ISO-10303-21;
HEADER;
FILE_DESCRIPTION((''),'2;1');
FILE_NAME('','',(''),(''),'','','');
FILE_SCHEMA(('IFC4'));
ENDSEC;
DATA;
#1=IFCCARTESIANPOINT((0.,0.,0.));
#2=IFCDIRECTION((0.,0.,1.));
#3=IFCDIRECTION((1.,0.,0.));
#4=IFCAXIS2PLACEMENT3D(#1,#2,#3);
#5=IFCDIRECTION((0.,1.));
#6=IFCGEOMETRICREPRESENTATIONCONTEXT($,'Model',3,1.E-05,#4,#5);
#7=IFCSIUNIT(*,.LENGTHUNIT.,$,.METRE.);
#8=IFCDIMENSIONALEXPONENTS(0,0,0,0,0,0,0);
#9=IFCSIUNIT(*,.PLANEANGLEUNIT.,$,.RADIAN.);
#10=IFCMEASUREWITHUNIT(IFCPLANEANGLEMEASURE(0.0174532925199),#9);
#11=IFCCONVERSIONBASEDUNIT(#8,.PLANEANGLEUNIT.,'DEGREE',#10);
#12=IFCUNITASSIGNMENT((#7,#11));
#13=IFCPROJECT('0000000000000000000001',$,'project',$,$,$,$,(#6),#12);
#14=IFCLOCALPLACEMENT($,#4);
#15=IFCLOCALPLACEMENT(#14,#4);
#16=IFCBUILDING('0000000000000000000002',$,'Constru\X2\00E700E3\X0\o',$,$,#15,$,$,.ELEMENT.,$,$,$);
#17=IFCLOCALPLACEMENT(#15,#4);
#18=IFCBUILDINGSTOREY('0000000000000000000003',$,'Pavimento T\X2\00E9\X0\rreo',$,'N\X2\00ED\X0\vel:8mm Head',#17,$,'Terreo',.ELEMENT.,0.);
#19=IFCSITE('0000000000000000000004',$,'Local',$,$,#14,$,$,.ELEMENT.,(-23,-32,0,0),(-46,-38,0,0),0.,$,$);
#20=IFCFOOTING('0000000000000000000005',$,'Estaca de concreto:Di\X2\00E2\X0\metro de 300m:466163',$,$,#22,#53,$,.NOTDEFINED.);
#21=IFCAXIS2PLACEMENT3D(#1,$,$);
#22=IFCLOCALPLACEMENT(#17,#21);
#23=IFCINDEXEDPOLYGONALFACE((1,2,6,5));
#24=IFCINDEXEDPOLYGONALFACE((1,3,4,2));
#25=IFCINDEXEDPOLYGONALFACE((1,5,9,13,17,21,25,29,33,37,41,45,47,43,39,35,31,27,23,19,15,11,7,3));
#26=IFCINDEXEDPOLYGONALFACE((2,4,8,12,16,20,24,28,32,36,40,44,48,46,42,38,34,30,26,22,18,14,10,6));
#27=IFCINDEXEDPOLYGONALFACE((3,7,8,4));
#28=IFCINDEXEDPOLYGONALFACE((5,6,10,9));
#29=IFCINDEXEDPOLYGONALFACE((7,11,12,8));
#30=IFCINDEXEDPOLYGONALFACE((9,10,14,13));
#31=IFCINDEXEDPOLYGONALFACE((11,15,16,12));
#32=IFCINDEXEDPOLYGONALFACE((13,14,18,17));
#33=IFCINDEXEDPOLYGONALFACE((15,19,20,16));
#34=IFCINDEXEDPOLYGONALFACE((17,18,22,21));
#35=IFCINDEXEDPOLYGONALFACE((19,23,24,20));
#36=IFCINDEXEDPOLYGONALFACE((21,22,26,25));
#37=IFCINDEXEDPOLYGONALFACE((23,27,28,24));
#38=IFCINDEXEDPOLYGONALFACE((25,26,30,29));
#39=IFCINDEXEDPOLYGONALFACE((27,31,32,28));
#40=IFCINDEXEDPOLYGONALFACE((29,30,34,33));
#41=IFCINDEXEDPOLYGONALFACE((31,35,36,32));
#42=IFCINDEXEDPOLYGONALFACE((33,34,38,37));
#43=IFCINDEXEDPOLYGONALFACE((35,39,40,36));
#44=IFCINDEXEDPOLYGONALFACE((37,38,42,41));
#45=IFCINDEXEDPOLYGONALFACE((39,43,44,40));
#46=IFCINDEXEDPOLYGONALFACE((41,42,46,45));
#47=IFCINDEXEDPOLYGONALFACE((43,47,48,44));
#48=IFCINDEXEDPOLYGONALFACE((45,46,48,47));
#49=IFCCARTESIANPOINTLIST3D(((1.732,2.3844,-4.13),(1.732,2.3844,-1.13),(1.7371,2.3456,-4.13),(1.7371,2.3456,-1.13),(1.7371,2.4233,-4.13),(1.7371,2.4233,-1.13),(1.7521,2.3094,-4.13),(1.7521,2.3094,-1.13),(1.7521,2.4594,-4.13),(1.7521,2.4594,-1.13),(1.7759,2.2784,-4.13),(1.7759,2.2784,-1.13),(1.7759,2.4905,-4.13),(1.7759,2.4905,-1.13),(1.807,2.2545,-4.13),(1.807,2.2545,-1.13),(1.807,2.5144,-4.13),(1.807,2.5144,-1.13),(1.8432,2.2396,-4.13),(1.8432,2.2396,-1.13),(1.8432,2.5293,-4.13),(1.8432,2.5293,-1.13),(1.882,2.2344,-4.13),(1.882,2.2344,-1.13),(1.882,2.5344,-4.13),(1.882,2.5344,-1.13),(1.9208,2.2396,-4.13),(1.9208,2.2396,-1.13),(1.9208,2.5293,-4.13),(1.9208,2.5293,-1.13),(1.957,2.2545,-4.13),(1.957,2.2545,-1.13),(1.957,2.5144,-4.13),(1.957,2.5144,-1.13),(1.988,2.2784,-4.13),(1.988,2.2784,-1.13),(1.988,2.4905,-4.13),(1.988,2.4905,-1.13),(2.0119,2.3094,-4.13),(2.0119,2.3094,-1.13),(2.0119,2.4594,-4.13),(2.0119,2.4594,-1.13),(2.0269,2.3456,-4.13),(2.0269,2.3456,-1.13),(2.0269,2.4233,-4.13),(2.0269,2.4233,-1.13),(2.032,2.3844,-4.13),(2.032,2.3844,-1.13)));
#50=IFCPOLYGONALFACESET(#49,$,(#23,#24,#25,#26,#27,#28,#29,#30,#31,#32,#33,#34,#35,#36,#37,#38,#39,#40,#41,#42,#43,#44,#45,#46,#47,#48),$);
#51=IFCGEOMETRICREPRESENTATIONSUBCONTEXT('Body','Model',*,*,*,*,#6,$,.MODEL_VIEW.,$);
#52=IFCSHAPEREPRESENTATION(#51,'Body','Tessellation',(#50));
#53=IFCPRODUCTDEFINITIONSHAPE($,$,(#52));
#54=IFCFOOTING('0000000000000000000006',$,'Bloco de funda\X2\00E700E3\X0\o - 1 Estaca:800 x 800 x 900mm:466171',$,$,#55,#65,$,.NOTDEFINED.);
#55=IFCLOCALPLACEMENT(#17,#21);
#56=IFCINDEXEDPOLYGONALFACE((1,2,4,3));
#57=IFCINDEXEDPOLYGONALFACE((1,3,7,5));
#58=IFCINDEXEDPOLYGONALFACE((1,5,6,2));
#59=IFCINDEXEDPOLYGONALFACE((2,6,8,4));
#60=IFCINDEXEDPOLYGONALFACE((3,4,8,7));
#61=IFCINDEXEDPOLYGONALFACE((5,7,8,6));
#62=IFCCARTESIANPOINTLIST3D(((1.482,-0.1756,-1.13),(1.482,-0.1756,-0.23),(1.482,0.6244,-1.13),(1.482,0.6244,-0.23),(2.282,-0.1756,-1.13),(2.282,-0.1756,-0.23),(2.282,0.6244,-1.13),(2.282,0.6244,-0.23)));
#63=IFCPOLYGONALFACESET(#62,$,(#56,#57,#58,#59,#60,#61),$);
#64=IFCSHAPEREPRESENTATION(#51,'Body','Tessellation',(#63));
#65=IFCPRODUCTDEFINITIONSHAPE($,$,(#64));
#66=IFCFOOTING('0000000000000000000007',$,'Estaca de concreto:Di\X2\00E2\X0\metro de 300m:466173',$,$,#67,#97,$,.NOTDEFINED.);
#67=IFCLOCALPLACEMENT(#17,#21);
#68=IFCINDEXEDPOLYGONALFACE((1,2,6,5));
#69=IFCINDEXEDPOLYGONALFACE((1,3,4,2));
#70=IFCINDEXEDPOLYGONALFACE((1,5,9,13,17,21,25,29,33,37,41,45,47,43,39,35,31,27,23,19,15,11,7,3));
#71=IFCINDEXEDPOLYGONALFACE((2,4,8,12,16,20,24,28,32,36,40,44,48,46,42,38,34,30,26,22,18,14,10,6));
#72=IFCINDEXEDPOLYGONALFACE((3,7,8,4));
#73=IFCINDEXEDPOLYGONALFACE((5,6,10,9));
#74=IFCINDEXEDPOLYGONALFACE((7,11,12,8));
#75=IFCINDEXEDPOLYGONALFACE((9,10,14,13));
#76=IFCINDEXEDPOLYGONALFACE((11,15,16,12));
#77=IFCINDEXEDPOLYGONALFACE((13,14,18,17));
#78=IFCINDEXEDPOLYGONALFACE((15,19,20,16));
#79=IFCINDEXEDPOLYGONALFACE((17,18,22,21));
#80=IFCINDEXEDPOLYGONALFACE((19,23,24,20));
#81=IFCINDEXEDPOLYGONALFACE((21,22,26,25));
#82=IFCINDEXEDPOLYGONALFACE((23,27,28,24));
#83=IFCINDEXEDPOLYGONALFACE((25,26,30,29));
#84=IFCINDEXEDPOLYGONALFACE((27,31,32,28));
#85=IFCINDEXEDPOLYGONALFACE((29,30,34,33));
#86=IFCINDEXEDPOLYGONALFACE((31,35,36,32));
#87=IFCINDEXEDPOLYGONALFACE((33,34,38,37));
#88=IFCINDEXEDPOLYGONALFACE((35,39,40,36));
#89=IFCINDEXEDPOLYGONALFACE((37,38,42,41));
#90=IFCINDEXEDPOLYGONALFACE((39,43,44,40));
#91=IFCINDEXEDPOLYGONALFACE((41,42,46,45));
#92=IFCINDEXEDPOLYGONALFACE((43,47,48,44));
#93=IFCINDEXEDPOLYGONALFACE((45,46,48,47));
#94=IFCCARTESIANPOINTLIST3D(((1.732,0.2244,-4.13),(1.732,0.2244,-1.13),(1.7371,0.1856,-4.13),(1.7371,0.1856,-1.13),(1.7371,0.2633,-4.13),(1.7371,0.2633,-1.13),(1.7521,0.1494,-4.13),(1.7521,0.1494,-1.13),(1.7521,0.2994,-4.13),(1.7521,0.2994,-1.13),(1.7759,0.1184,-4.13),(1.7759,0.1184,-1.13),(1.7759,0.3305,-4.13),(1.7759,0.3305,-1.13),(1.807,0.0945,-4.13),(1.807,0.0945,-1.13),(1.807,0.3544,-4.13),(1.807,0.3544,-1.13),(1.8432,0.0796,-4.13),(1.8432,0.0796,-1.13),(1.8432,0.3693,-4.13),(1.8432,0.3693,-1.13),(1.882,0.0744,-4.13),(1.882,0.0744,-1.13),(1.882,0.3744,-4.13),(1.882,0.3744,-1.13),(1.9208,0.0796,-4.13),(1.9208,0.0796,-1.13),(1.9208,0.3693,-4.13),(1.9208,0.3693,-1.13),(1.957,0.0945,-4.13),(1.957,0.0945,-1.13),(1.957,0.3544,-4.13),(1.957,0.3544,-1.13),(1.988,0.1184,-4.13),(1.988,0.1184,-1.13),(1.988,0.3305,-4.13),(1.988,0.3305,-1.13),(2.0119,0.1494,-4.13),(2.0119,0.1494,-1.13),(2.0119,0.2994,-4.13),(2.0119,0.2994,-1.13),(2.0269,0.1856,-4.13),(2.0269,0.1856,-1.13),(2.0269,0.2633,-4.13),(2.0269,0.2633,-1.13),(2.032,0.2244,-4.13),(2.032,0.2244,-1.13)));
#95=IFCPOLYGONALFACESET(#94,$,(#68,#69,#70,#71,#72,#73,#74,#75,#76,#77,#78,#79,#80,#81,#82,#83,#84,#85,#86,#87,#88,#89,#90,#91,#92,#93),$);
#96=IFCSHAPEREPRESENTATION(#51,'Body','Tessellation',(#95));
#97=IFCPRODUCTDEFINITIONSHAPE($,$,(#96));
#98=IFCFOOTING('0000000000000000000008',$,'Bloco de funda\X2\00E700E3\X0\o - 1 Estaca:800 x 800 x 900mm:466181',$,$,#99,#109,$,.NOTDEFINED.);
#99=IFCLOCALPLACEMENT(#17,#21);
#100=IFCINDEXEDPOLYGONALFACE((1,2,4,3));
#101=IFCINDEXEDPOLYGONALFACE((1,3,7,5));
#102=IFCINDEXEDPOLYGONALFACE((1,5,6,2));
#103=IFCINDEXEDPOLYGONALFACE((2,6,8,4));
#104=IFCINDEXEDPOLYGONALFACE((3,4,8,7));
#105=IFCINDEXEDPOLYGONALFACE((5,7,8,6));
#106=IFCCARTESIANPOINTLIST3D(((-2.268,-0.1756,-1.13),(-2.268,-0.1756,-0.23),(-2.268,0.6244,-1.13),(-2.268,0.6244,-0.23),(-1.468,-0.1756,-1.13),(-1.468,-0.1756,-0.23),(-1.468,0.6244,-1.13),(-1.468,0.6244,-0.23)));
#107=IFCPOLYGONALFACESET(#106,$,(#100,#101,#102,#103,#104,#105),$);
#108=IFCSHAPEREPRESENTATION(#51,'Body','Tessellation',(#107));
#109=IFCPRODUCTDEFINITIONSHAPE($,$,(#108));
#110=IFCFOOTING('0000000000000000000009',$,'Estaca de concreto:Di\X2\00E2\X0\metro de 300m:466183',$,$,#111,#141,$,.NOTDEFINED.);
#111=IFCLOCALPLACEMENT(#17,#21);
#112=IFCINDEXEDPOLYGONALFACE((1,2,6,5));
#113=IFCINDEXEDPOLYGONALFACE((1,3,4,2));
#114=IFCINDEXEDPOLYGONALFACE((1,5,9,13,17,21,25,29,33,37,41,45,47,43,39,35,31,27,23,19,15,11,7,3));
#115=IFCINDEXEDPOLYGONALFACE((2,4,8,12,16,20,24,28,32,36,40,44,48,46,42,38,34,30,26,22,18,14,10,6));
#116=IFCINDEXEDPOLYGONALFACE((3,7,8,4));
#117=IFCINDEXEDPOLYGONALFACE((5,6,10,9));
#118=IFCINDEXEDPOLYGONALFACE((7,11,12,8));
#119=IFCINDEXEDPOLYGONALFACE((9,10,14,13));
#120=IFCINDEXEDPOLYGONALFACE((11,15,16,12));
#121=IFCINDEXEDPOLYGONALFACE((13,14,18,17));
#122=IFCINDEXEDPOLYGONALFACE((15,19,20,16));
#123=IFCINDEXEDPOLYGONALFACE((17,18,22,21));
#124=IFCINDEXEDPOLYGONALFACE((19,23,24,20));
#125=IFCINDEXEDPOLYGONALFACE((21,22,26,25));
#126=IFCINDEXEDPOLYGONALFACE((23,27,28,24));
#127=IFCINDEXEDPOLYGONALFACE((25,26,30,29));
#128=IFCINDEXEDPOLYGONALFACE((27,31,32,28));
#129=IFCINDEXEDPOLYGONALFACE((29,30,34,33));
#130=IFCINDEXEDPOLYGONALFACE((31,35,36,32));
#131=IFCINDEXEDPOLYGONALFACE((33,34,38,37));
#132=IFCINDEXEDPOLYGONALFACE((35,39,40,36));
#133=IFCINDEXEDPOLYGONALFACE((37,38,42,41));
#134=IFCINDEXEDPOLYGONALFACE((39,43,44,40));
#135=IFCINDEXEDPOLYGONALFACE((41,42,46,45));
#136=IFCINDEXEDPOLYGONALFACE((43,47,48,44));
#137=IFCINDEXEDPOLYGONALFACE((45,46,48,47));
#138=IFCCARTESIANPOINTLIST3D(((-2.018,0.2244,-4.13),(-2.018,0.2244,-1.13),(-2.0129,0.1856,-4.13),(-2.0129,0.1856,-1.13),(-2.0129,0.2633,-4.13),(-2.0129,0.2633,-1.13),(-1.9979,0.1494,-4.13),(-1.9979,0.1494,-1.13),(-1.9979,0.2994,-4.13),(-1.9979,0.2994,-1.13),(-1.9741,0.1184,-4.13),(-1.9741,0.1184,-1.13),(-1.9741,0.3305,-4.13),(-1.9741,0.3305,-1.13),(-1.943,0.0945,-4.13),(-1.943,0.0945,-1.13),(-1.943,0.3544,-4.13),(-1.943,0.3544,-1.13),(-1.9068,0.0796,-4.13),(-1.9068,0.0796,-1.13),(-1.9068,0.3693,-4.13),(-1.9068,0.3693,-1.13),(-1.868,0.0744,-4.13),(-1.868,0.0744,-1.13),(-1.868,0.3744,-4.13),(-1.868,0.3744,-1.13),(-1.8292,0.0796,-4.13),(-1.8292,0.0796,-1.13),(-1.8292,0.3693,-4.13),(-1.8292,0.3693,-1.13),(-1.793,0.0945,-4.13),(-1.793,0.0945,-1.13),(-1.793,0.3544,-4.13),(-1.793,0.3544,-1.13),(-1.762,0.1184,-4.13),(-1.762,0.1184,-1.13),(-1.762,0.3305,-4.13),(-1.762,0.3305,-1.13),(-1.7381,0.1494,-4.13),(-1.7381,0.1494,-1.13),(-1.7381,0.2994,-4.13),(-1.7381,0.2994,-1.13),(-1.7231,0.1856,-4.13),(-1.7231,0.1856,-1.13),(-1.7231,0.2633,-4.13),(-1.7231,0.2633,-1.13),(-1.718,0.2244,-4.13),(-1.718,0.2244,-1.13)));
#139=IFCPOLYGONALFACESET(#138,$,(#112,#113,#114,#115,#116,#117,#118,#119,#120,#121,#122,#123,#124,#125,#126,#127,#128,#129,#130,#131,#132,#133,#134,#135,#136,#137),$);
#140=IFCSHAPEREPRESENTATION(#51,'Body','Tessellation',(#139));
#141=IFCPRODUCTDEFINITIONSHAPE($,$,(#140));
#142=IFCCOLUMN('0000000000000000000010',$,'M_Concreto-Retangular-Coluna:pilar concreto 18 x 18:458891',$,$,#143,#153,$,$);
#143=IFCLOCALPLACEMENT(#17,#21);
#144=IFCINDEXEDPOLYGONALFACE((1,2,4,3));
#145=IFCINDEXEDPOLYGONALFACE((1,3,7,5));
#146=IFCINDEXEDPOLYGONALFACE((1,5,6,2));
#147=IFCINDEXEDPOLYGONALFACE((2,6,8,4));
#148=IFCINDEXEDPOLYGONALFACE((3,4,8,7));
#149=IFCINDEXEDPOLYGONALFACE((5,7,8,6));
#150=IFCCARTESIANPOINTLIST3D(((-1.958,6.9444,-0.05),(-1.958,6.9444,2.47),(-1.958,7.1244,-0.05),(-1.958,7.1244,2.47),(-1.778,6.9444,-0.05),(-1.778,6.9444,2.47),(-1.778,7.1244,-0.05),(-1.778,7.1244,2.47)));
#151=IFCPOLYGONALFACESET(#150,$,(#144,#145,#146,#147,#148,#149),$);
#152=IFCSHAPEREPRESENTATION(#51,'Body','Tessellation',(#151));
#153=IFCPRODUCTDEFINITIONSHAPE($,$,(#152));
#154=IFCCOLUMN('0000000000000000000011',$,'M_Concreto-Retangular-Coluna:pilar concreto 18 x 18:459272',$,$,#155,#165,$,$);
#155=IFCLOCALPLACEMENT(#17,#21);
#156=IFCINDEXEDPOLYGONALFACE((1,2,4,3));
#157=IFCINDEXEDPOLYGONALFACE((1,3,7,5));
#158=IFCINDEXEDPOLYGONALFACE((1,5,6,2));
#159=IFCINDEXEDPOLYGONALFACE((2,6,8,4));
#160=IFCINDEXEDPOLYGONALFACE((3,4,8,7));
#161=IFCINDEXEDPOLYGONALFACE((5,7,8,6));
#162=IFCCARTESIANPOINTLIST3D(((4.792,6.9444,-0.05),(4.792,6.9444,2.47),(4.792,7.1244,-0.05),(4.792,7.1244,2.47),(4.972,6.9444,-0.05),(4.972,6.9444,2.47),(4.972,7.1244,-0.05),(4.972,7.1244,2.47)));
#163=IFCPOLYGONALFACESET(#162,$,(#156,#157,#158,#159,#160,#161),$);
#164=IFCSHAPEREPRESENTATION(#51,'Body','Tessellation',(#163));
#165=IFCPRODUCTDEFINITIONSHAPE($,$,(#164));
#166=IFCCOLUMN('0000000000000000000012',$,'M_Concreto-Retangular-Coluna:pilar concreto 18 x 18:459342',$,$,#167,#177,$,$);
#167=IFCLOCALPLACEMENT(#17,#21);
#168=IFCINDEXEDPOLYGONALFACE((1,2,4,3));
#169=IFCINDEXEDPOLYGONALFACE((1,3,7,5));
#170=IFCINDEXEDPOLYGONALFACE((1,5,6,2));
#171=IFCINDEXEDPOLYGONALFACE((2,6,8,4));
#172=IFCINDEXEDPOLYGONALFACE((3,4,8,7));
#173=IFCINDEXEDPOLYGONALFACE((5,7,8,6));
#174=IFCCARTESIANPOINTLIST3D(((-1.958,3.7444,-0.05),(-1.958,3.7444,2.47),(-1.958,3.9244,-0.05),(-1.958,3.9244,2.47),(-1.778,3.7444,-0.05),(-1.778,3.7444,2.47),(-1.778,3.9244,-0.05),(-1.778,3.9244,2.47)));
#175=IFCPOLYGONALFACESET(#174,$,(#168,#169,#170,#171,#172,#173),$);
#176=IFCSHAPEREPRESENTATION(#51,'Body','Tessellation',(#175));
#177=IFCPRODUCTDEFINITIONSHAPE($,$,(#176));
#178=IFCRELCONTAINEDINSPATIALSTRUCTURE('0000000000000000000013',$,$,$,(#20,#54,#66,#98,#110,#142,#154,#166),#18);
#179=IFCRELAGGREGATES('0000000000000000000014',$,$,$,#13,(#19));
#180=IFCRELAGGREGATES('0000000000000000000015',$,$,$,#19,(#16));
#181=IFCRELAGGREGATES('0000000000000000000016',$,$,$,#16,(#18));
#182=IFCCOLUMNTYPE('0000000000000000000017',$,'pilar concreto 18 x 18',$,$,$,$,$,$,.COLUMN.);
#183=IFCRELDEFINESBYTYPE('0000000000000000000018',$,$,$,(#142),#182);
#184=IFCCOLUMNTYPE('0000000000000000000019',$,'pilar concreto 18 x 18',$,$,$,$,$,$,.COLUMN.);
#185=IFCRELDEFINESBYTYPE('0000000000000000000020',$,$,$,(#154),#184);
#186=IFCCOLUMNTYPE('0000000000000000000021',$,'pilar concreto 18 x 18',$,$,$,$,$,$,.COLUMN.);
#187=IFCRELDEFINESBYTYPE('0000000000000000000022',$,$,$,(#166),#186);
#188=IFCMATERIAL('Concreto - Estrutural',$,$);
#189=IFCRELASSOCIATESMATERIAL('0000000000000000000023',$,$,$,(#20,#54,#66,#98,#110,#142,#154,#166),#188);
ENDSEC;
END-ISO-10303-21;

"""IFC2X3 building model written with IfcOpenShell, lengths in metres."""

from ifc_helpers import new_model, entity, si_unit, converted_unit, point, direction, frame, frame_2d, origin_with_axes, origin_2d_with_axis, place, context, subcontext, project, spatial, polyline, circle_curve, parameter, trimmed, segment, composite_curve, rectangle, outline, extrude, material, type_object, element, save


model = new_model("IFC2X3")

# Units and contexts
model_context = context("Model", 3, precision=1e-05, world=origin_with_axes(), true_north=direction((0.0, 1.0)))
body_context = subcontext(model_context, "Body", "Model", "MODEL_VIEW")
ifc_project = project(units=[si_unit("LENGTHUNIT", "METRE"), converted_unit("PLANEANGLEUNIT", "DEGREE", entity("IfcPlaneAngleMeasure", 0.0174532925199), si_unit("PLANEANGLEUNIT", "RADIAN"), dimensions=[0, 0, 0, 0, 0, 0, 0])], contexts=[model_context])

# Site, building, storey
site_placement = place(None, origin_with_axes())
site = spatial("IfcSite", under=ifc_project, at=site_placement, Name="Local", CompositionType="ELEMENT", RefLatitude=(-23, -32, 0, 0), RefLongitude=(-46, -38, 0, 0), RefElevation=0.0)
building_placement = place(site_placement, origin_with_axes())
building = spatial("IfcBuilding", under=site, at=building_placement, Name="Construção", CompositionType="ELEMENT")
storey_placement = place(building_placement, origin_with_axes())
storey = spatial("IfcBuildingStorey", under=building, at=storey_placement, Name="Pavimento Térreo", ObjectType="Nível:8mm Head", LongName="Terreo", CompositionType="ELEMENT", Elevation=0.0)

# Footings
ifc_material = material(Name="Concreto - Estrutural")
footing_1_placement = place(storey_placement, frame((2.032, 2.3844, -1.13), z_axis=(0.0, 0.0, 1.0), x_axis=(1.0, 0.0, 0.0)))
element("IfcFooting", 1, at=footing_1_placement, inside=storey, material=ifc_material, Name="Estaca de concreto:Diâmetro de 300m:466163", PredefinedType="NOTDEFINED", context=body_context, shape_type="SweptSolid", body=[
    extrude(outline(composite_curve([segment(trimmed(circle_curve(frame_2d((-0.15, 0.0), x_axis=(1.0, 0.0)), 0.15), [point((0.0, 0.0)), parameter(0.0)], [point((-0.15, 0.15)), parameter(90.0)], True, "CARTESIAN"), True, "CONTINUOUS"), segment(trimmed(circle_curve(frame_2d((-0.15, 0.0), x_axis=(0.0, 1.0)), 0.15), [point((-0.15, 0.15)), parameter(0.0)], [point((-0.3, 0.0)), parameter(90.0)], True, "CARTESIAN"), True, "CONTINUOUS"), segment(trimmed(circle_curve(frame_2d((-0.15, 0.0), x_axis=(-1.0, 0.0)), 0.15), [point((-0.3, 0.0)), parameter(0.0)], [point((-0.15, -0.15)), parameter(90.0)], True, "CARTESIAN"), True, "CONTINUOUS"), segment(trimmed(circle_curve(frame_2d((-0.15, 0.0), x_axis=(0.0, -1.0)), 0.15), [point((-0.15, -0.15)), parameter(0.0)], [point((0.0, 0.0)), parameter(90.0)], True, "CARTESIAN"), True, "CONTINUOUS")], self_intersect=False)), frame((0.0, 0.0, -3.0), z_axis=(0.0, 0.0, 1.0), x_axis=(1.0, 0.0, 0.0)), (0.0, 0.0, 1.0), 3.0),
])
footing_2_placement = place(storey_placement, frame((1.482, 0.6244, -0.23), z_axis=(0.0, 0.0, 1.0), x_axis=(1.0, 0.0, 0.0)))
element("IfcFooting", 2, at=footing_2_placement, inside=storey, material=ifc_material, Name="Bloco de fundação - 1 Estaca:800 x 800 x 900mm:466171", PredefinedType="NOTDEFINED", context=body_context, shape_type="SweptSolid", body=[
    extrude(outline(polyline([(0.0, 0.0), (0.0, -0.8), (0.8, -0.8), (0.8, 0.0), (0.0, 0.0)])), frame((0.0, 0.0, -0.9), z_axis=(0.0, 0.0, 1.0), x_axis=(1.0, 0.0, 0.0)), (0.0, 0.0, 1.0), 0.9),
])
footing_3_placement = place(storey_placement, frame((2.032, 0.2244, -1.13), z_axis=(0.0, 0.0, 1.0), x_axis=(1.0, 0.0, 0.0)))
element("IfcFooting", 3, at=footing_3_placement, inside=storey, material=ifc_material, Name="Estaca de concreto:Diâmetro de 300m:466173", PredefinedType="NOTDEFINED", context=body_context, shape_type="SweptSolid", body=[
    extrude(outline(composite_curve([segment(trimmed(circle_curve(frame_2d((-0.15, 0.0), x_axis=(1.0, 0.0)), 0.15), [point((0.0, 0.0)), parameter(0.0)], [point((-0.15, 0.15)), parameter(90.0)], True, "CARTESIAN"), True, "CONTINUOUS"), segment(trimmed(circle_curve(frame_2d((-0.15, 0.0), x_axis=(0.0, 1.0)), 0.15), [point((-0.15, 0.15)), parameter(0.0)], [point((-0.3, 0.0)), parameter(90.0)], True, "CARTESIAN"), True, "CONTINUOUS"), segment(trimmed(circle_curve(frame_2d((-0.15, 0.0), x_axis=(-1.0, 0.0)), 0.15), [point((-0.3, 0.0)), parameter(0.0)], [point((-0.15, -0.15)), parameter(90.0)], True, "CARTESIAN"), True, "CONTINUOUS"), segment(trimmed(circle_curve(frame_2d((-0.15, 0.0), x_axis=(0.0, -1.0)), 0.15), [point((-0.15, -0.15)), parameter(0.0)], [point((0.0, 0.0)), parameter(90.0)], True, "CARTESIAN"), True, "CONTINUOUS")], self_intersect=False)), frame((0.0, 0.0, -3.0), z_axis=(0.0, 0.0, 1.0), x_axis=(1.0, 0.0, 0.0)), (0.0, 0.0, 1.0), 3.0),
])
footing_4_placement = place(storey_placement, frame((-2.268, 0.6244, -0.23), z_axis=(0.0, 0.0, 1.0), x_axis=(1.0, 0.0, 0.0)))
element("IfcFooting", 4, at=footing_4_placement, inside=storey, material=ifc_material, Name="Bloco de fundação - 1 Estaca:800 x 800 x 900mm:466181", PredefinedType="NOTDEFINED", context=body_context, shape_type="SweptSolid", body=[
    extrude(outline(polyline([(0.0, 0.0), (0.0, -0.8), (0.8, -0.8), (0.8, 0.0), (0.0, 0.0)])), frame((0.0, 0.0, -0.9), z_axis=(0.0, 0.0, 1.0), x_axis=(1.0, 0.0, 0.0)), (0.0, 0.0, 1.0), 0.9),
])
footing_5_placement = place(storey_placement, frame((-1.718, 0.2244, -1.13), z_axis=(0.0, 0.0, 1.0), x_axis=(1.0, 0.0, 0.0)))
element("IfcFooting", 5, at=footing_5_placement, inside=storey, material=ifc_material, Name="Estaca de concreto:Diâmetro de 300m:466183", PredefinedType="NOTDEFINED", context=body_context, shape_type="SweptSolid", body=[
    extrude(outline(composite_curve([segment(trimmed(circle_curve(frame_2d((-0.15, 0.0), x_axis=(1.0, 0.0)), 0.15), [point((0.0, 0.0)), parameter(0.0)], [point((-0.15, 0.15)), parameter(90.0)], True, "CARTESIAN"), True, "CONTINUOUS"), segment(trimmed(circle_curve(frame_2d((-0.15, 0.0), x_axis=(0.0, 1.0)), 0.15), [point((-0.15, 0.15)), parameter(0.0)], [point((-0.3, 0.0)), parameter(90.0)], True, "CARTESIAN"), True, "CONTINUOUS"), segment(trimmed(circle_curve(frame_2d((-0.15, 0.0), x_axis=(-1.0, 0.0)), 0.15), [point((-0.3, 0.0)), parameter(0.0)], [point((-0.15, -0.15)), parameter(90.0)], True, "CARTESIAN"), True, "CONTINUOUS"), segment(trimmed(circle_curve(frame_2d((-0.15, 0.0), x_axis=(0.0, -1.0)), 0.15), [point((-0.15, -0.15)), parameter(0.0)], [point((0.0, 0.0)), parameter(90.0)], True, "CARTESIAN"), True, "CONTINUOUS")], self_intersect=False)), frame((0.0, 0.0, -3.0), z_axis=(0.0, 0.0, 1.0), x_axis=(1.0, 0.0, 0.0)), (0.0, 0.0, 1.0), 3.0),
])

# Columns
column_type_1 = type_object("IfcColumnType", Name="pilar concreto 18 x 18", PredefinedType="COLUMN")
column_1_placement = place(storey_placement, frame((-1.868, 7.0344, -0.05), z_axis=(0.0, 0.0, 1.0), x_axis=(0.0, -1.0, 0.0)))
element("IfcColumn", 6, at=column_1_placement, inside=storey, type_object=column_type_1, material=ifc_material, Name="M_Concreto-Retangular-Coluna:pilar concreto 18 x 18:458891", context=body_context, shape_type="SweptSolid", body=[
    extrude(rectangle(XDim=0.18, YDim=0.18, at=origin_2d_with_axis()), origin_with_axes(), (0.0, 0.0, 1.0), 2.52),
])
column_type_2 = type_object("IfcColumnType", Name="pilar concreto 18 x 18", PredefinedType="COLUMN")
column_2_placement = place(storey_placement, frame((4.882, 7.0344, -0.05), z_axis=(0.0, 0.0, 1.0), x_axis=(0.0, -1.0, 0.0)))
element("IfcColumn", 7, at=column_2_placement, inside=storey, type_object=column_type_2, material=ifc_material, Name="M_Concreto-Retangular-Coluna:pilar concreto 18 x 18:459272", context=body_context, shape_type="SweptSolid", body=[
    extrude(rectangle(XDim=0.18, YDim=0.18, at=origin_2d_with_axis()), origin_with_axes(), (0.0, 0.0, 1.0), 2.52),
])
column_type_3 = type_object("IfcColumnType", Name="pilar concreto 18 x 18", PredefinedType="COLUMN")
column_3_placement = place(storey_placement, frame((-1.868, 3.8344, -0.05), z_axis=(0.0, 0.0, 1.0), x_axis=(0.0, -1.0, 0.0)))
element("IfcColumn", 8, at=column_3_placement, inside=storey, type_object=column_type_3, material=ifc_material, Name="M_Concreto-Retangular-Coluna:pilar concreto 18 x 18:459342", context=body_context, shape_type="SweptSolid", body=[
    extrude(rectangle(XDim=0.18, YDim=0.18, at=origin_2d_with_axis()), origin_with_axes(), (0.0, 0.0, 1.0), 2.52),
])

save(model, "model.ifc")
